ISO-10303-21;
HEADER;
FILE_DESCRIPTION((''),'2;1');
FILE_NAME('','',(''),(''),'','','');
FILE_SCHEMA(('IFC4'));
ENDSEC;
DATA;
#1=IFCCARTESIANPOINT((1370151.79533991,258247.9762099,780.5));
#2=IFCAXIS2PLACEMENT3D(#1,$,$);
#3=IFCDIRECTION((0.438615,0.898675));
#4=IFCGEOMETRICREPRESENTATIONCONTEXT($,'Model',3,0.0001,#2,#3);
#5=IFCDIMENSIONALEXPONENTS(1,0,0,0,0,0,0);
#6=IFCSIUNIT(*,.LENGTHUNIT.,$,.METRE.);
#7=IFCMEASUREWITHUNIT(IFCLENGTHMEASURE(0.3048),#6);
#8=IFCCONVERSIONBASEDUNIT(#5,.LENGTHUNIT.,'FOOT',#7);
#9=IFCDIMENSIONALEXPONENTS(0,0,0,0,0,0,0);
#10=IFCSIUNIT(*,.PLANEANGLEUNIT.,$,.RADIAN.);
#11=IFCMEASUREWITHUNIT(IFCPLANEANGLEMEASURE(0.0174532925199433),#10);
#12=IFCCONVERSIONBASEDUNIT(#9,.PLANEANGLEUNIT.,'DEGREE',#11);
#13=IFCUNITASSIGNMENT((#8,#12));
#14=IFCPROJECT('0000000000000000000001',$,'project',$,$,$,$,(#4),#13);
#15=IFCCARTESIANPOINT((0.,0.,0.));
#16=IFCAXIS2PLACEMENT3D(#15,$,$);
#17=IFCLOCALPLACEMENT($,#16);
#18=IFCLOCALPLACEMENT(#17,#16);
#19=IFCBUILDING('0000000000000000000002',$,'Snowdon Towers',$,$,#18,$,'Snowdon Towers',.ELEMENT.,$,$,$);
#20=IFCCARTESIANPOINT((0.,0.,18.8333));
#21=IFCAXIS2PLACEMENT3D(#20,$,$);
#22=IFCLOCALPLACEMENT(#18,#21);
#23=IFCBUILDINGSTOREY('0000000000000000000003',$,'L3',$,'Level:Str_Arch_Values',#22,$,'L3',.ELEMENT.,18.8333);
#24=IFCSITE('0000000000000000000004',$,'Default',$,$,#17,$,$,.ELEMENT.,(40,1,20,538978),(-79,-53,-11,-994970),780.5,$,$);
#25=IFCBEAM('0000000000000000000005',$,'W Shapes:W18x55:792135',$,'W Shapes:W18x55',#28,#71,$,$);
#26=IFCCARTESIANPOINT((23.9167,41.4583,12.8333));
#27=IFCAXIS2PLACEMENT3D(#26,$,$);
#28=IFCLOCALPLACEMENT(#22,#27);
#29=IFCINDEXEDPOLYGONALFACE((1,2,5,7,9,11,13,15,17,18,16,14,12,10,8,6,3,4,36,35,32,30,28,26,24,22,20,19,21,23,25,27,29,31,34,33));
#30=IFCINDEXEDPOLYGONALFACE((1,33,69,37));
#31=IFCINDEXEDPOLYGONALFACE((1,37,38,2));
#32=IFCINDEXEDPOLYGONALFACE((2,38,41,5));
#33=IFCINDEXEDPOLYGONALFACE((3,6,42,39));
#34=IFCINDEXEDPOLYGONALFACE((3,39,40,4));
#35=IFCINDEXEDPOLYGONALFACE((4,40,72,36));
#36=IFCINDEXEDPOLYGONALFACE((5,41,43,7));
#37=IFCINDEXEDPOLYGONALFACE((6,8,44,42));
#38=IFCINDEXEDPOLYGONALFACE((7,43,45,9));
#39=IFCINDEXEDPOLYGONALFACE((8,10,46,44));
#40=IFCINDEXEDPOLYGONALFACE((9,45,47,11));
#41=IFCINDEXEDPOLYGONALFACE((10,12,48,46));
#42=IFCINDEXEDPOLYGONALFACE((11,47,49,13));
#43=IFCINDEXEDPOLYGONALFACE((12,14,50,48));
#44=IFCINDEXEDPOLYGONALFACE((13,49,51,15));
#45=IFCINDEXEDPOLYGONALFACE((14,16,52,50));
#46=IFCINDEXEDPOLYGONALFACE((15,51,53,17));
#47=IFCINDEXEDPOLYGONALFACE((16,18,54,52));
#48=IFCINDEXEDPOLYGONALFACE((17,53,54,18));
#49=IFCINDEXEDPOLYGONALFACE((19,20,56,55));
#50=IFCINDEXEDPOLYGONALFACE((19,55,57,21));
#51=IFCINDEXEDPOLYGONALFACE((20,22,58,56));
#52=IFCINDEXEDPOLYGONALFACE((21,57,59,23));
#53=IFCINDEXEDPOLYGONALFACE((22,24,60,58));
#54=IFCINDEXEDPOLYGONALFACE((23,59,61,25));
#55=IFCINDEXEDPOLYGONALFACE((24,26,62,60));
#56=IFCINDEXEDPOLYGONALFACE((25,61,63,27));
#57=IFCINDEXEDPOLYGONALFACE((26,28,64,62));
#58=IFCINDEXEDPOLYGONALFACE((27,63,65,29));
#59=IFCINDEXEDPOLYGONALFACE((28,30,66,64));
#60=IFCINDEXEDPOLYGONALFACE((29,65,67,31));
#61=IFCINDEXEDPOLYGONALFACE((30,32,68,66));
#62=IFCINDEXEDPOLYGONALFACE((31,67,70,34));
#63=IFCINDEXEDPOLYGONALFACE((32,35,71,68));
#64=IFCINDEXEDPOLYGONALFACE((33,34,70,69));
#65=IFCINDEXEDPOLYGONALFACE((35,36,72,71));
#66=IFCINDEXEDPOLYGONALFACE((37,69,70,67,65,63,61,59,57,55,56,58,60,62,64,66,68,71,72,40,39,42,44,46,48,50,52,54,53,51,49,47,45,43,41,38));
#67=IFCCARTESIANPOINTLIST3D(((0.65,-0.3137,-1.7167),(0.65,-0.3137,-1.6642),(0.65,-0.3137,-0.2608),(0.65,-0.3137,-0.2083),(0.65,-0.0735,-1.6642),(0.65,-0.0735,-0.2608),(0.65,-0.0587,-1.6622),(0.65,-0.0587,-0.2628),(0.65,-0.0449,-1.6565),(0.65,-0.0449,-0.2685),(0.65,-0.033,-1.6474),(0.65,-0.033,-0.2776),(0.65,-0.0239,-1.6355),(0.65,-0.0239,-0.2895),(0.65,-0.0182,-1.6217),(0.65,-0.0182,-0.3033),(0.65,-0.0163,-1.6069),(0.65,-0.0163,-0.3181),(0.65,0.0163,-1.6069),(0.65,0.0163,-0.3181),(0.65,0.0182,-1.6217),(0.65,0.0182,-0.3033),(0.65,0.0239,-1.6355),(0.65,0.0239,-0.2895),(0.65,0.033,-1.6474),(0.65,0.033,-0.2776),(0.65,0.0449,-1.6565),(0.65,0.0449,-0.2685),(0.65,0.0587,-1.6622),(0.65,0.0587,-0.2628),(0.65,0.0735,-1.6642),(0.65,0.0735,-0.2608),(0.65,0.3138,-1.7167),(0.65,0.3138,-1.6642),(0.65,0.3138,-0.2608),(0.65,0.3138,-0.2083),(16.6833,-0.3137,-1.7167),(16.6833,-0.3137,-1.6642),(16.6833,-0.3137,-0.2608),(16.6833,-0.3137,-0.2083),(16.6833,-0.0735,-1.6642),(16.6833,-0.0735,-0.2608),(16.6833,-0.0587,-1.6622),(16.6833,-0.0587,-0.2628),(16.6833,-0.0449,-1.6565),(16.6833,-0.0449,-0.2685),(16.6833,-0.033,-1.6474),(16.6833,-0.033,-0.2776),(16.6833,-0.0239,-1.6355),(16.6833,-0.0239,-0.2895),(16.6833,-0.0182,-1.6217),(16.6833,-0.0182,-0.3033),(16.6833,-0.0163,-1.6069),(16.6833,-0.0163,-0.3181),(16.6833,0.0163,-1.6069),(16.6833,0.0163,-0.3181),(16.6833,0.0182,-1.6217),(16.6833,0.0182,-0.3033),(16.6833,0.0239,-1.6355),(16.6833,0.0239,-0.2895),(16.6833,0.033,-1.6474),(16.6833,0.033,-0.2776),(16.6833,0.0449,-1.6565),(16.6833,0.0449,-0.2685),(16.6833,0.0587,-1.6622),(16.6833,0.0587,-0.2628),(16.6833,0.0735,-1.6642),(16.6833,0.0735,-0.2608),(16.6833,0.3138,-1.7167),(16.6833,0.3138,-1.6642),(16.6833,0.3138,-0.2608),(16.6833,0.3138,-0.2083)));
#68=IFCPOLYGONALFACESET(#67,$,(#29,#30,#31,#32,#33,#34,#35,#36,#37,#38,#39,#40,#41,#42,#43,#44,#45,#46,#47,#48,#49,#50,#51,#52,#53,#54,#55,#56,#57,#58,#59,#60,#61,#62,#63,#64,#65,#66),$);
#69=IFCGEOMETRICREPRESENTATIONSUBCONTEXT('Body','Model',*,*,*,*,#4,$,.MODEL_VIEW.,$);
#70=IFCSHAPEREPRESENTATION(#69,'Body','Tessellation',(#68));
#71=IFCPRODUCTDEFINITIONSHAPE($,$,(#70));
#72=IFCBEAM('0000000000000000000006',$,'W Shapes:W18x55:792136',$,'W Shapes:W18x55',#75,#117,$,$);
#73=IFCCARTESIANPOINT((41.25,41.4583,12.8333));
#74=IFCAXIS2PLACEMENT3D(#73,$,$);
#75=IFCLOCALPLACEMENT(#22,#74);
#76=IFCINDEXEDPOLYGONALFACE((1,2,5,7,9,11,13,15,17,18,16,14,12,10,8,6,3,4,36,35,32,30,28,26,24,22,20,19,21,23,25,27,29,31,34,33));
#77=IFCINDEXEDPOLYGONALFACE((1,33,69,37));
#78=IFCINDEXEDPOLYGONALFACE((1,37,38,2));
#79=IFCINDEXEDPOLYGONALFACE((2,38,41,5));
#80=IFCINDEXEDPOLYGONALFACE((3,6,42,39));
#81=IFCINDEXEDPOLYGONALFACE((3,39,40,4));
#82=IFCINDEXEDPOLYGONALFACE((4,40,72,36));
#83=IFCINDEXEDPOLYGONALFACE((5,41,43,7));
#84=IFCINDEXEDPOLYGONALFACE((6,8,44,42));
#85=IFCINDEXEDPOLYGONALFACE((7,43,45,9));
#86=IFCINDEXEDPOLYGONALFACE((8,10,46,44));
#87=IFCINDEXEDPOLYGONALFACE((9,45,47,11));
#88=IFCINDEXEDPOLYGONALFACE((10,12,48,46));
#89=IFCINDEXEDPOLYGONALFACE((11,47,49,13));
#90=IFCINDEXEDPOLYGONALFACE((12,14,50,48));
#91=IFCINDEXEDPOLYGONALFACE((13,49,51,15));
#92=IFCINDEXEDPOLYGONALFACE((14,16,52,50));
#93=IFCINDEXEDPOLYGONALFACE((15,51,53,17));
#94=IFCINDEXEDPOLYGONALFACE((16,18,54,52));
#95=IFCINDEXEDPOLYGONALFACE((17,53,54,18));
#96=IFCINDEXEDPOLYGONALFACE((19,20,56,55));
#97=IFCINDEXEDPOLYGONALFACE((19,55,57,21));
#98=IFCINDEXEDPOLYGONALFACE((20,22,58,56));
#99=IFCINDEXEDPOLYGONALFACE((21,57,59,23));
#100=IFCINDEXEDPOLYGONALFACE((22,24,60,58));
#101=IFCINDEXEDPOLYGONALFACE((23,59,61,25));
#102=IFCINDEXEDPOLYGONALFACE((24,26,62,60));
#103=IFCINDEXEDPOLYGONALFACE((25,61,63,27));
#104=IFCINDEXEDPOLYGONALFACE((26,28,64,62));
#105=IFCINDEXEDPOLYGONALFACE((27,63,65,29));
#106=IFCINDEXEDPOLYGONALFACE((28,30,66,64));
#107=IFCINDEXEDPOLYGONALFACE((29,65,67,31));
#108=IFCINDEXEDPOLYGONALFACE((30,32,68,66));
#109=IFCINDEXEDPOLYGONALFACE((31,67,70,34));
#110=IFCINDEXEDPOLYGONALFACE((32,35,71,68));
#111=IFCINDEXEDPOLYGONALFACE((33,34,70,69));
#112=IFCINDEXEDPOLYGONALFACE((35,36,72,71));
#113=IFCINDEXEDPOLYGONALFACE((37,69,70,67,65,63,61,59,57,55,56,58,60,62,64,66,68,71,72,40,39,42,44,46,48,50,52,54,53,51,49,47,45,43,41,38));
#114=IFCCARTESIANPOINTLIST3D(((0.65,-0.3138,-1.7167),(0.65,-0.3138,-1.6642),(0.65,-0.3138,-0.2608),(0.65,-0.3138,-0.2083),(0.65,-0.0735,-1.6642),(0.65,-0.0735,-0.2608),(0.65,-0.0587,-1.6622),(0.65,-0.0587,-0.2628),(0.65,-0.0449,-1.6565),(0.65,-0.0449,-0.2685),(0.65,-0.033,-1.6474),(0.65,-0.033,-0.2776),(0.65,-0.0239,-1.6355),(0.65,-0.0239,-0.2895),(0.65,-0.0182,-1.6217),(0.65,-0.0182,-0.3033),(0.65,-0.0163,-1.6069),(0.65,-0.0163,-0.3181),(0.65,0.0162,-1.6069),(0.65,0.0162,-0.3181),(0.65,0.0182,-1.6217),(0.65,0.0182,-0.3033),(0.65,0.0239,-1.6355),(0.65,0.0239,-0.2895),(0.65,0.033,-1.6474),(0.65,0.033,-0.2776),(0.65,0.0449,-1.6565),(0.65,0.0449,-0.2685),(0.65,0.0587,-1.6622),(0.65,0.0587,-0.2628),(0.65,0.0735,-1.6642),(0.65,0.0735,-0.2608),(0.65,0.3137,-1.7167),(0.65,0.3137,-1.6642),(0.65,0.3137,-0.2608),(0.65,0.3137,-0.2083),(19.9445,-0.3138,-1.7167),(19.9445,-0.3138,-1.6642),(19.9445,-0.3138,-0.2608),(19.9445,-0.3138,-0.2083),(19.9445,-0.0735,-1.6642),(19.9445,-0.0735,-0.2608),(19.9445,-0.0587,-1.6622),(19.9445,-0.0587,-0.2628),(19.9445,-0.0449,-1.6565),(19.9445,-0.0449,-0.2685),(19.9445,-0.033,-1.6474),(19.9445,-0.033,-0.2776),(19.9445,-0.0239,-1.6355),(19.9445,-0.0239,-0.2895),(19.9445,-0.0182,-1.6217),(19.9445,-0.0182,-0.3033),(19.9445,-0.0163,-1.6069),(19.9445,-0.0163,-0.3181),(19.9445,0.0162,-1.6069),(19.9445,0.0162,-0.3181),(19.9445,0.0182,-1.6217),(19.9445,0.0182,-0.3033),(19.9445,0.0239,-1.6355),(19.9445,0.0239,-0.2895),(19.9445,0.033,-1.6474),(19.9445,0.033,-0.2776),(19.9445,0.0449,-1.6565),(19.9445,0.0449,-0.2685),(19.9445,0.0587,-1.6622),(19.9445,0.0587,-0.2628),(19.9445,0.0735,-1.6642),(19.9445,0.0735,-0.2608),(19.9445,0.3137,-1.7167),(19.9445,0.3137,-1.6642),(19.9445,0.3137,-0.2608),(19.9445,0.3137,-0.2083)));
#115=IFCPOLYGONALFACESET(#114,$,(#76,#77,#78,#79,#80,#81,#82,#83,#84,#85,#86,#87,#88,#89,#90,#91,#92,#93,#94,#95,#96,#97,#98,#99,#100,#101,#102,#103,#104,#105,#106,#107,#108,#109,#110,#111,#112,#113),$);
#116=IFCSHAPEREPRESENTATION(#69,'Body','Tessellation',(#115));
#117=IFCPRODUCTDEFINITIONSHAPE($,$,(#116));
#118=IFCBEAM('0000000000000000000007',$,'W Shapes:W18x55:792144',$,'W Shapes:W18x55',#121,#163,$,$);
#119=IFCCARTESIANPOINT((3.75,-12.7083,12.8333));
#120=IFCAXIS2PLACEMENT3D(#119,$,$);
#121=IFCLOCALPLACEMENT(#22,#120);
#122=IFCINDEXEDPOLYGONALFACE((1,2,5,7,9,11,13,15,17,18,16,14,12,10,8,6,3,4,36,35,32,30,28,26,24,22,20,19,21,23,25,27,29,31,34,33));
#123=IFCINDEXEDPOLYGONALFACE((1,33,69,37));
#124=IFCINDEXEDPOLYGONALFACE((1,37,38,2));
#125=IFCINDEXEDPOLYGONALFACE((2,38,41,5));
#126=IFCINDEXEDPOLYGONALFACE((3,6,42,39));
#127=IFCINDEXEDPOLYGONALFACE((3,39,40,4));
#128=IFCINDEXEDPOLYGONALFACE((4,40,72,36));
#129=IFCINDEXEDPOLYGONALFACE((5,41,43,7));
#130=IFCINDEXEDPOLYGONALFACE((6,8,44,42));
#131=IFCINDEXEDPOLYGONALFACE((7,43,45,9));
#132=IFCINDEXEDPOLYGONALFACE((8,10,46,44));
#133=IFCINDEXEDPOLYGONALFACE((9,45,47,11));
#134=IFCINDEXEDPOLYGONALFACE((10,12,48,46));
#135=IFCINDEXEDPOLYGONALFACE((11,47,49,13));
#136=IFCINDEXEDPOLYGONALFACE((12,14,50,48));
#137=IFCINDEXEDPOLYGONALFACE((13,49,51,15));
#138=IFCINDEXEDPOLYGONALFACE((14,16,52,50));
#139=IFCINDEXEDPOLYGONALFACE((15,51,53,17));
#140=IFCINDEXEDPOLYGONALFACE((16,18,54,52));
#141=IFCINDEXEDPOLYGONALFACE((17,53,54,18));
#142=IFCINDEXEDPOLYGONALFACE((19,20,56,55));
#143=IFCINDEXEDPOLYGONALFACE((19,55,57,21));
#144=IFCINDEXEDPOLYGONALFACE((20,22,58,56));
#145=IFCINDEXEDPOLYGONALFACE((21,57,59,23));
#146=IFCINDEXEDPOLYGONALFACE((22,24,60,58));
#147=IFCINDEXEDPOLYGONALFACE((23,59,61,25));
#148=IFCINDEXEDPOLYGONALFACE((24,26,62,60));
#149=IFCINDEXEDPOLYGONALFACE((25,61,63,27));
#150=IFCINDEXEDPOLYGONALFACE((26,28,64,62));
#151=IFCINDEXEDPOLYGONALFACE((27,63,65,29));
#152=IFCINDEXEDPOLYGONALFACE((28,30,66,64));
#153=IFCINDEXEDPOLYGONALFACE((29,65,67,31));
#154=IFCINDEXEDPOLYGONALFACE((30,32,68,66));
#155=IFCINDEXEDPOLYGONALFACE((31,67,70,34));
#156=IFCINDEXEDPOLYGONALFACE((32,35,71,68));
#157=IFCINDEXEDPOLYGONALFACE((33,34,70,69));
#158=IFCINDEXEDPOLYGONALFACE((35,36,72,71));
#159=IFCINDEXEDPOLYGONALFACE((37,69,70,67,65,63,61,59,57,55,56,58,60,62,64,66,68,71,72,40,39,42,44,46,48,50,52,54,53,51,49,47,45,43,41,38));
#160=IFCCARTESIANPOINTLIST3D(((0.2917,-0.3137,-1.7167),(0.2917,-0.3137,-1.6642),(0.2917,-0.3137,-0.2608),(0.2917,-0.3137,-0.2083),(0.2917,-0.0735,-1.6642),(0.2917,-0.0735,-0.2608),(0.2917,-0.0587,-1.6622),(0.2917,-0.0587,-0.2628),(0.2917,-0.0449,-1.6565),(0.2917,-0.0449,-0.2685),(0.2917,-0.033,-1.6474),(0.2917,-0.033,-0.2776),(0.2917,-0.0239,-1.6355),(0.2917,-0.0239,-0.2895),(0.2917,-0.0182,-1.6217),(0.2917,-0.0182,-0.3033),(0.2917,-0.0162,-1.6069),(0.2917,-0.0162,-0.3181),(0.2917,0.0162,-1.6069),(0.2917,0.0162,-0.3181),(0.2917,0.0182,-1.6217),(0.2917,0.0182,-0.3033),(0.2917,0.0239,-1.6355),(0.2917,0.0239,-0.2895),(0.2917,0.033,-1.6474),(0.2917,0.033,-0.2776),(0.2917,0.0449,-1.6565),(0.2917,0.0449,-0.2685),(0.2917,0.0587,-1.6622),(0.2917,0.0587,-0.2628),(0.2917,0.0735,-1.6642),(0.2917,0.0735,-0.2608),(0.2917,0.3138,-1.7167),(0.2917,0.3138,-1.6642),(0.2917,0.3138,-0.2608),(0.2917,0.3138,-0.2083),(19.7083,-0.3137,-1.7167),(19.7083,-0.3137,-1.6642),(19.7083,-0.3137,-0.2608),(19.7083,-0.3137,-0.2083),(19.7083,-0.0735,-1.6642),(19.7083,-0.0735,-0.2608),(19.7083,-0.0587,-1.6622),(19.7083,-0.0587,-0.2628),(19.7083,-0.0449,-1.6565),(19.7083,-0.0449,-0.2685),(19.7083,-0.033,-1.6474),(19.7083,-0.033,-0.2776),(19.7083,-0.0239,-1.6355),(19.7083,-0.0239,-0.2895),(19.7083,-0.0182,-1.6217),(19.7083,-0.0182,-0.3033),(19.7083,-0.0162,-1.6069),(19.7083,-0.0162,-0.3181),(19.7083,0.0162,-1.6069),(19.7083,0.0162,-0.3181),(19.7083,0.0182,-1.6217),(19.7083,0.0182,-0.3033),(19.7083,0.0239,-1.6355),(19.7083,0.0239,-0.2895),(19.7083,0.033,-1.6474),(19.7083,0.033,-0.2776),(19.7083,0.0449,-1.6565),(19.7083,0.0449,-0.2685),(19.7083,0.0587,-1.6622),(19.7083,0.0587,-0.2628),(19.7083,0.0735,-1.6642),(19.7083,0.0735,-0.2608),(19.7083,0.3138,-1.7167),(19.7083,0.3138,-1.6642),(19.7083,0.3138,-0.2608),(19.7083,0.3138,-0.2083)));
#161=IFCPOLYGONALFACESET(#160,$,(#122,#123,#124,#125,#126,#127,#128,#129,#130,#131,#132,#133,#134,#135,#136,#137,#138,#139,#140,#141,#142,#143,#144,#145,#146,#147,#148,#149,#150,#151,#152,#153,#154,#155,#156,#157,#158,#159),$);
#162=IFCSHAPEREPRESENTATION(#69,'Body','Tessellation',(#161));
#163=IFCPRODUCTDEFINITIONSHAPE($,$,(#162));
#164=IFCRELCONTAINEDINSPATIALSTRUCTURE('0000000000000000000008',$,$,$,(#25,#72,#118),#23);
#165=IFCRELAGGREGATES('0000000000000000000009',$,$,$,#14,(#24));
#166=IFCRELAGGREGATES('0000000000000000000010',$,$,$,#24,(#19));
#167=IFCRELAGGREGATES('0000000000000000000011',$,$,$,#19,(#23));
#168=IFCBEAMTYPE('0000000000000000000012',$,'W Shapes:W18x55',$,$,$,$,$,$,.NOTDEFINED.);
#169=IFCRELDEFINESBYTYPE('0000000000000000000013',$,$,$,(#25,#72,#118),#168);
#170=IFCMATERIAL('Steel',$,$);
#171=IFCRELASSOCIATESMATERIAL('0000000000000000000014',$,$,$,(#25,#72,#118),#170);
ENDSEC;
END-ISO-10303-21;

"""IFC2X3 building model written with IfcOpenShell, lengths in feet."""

from ifc_helpers import new_model, entity, si_unit, converted_unit, direction, frame, frame_2d, origin, place, context, subcontext, project, spatial, i_section, extrude, material, type_object, element, save


model = new_model("IFC2X3")

# Units and contexts
model_context = context("Model", 3, precision=0.0001, world=frame((1370151.79533991, 258247.9762099, 780.5)), true_north=direction((0.438615, 0.898675)))
body_context = subcontext(model_context, "Body", "Model", "MODEL_VIEW")
ifc_project = project(units=[converted_unit("LENGTHUNIT", "FOOT", entity("IfcLengthMeasure", 0.3048), si_unit("LENGTHUNIT", "METRE"), dimensions=[1, 0, 0, 0, 0, 0, 0]), converted_unit("PLANEANGLEUNIT", "DEGREE", entity("IfcPlaneAngleMeasure", 0.0174532925199433), si_unit("PLANEANGLEUNIT", "RADIAN"), dimensions=[0, 0, 0, 0, 0, 0, 0])], contexts=[model_context])

# Site, building, storey
site_placement = place(None, origin())
site = spatial("IfcSite", under=ifc_project, at=site_placement, Name="Default", CompositionType="ELEMENT", RefLatitude=(40, 1, 20, 538978), RefLongitude=(-79, -53, -11, -994970), RefElevation=780.5)
building_placement = place(site_placement, origin())
building = spatial("IfcBuilding", under=site, at=building_placement, Name="Snowdon Towers", LongName="Snowdon Towers", CompositionType="ELEMENT")
storey_placement = place(building_placement, frame((0.0, 0.0, 18.8333)))
storey = spatial("IfcBuildingStorey", under=building, at=storey_placement, Name="L3", ObjectType="Level:Str_Arch_Values", LongName="L3", CompositionType="ELEMENT", Elevation=18.8333)

# Beams
ifc_material = material(Name="Steel")
beam_type_1 = type_object("IfcBeamType", Name="W Shapes:W18x55", PredefinedType="NOTDEFINED")
beam_1_placement = place(storey_placement, frame((23.9167, 41.4583, 12.8333)))
element("IfcBeam", 1, at=beam_1_placement, inside=storey, type_object=beam_type_1, material=ifc_material, Name="W Shapes:W18x55:792135", ObjectType="W Shapes:W18x55", context=body_context, shape_type="SweptSolid", body=[
    extrude(i_section(OverallWidth=0.6275, OverallDepth=1.5083, WebThickness=0.0325, FlangeThickness=0.0525, FilletRadius=0.0573, at=frame_2d((0.0, 0.0), x_axis=(0.0, 1.0))), frame((0.65, 0.0, -0.9625), z_axis=(1.0, 0.0, 0.0), x_axis=(0.0, 0.0, -1.0)), (0.0, 0.0, 1.0), 16.0333),
])
beam_2_placement = place(storey_placement, frame((41.25, 41.4583, 12.8333)))
element("IfcBeam", 2, at=beam_2_placement, inside=storey, type_object=beam_type_1, material=ifc_material, Name="W Shapes:W18x55:792136", ObjectType="W Shapes:W18x55", context=body_context, shape_type="SweptSolid", body=[
    extrude(i_section(OverallWidth=0.6275, OverallDepth=1.5083, WebThickness=0.0325, FlangeThickness=0.0525, FilletRadius=0.0573, at=frame_2d((0.0, 0.0), x_axis=(0.0, 1.0))), frame((0.65, 0.0, -0.9625), z_axis=(1.0, 0.0, 0.0), x_axis=(0.0, 0.0, -1.0)), (0.0, 0.0, 1.0), 19.2945),
])
beam_3_placement = place(storey_placement, frame((3.75, -12.7083, 12.8333)))
element("IfcBeam", 3, at=beam_3_placement, inside=storey, type_object=beam_type_1, material=ifc_material, Name="W Shapes:W18x55:792144", ObjectType="W Shapes:W18x55", context=body_context, shape_type="SweptSolid", body=[
    extrude(i_section(OverallWidth=0.6275, OverallDepth=1.5083, WebThickness=0.0325, FlangeThickness=0.0525, FilletRadius=0.0573, at=frame_2d((0.0, 0.0), x_axis=(0.0, 1.0))), frame((0.2917, 0.0, -0.9625), z_axis=(1.0, 0.0, 0.0), x_axis=(0.0, 0.0, -1.0)), (0.0, 0.0, 1.0), 19.4167),
])

save(model, "model.ifc")
